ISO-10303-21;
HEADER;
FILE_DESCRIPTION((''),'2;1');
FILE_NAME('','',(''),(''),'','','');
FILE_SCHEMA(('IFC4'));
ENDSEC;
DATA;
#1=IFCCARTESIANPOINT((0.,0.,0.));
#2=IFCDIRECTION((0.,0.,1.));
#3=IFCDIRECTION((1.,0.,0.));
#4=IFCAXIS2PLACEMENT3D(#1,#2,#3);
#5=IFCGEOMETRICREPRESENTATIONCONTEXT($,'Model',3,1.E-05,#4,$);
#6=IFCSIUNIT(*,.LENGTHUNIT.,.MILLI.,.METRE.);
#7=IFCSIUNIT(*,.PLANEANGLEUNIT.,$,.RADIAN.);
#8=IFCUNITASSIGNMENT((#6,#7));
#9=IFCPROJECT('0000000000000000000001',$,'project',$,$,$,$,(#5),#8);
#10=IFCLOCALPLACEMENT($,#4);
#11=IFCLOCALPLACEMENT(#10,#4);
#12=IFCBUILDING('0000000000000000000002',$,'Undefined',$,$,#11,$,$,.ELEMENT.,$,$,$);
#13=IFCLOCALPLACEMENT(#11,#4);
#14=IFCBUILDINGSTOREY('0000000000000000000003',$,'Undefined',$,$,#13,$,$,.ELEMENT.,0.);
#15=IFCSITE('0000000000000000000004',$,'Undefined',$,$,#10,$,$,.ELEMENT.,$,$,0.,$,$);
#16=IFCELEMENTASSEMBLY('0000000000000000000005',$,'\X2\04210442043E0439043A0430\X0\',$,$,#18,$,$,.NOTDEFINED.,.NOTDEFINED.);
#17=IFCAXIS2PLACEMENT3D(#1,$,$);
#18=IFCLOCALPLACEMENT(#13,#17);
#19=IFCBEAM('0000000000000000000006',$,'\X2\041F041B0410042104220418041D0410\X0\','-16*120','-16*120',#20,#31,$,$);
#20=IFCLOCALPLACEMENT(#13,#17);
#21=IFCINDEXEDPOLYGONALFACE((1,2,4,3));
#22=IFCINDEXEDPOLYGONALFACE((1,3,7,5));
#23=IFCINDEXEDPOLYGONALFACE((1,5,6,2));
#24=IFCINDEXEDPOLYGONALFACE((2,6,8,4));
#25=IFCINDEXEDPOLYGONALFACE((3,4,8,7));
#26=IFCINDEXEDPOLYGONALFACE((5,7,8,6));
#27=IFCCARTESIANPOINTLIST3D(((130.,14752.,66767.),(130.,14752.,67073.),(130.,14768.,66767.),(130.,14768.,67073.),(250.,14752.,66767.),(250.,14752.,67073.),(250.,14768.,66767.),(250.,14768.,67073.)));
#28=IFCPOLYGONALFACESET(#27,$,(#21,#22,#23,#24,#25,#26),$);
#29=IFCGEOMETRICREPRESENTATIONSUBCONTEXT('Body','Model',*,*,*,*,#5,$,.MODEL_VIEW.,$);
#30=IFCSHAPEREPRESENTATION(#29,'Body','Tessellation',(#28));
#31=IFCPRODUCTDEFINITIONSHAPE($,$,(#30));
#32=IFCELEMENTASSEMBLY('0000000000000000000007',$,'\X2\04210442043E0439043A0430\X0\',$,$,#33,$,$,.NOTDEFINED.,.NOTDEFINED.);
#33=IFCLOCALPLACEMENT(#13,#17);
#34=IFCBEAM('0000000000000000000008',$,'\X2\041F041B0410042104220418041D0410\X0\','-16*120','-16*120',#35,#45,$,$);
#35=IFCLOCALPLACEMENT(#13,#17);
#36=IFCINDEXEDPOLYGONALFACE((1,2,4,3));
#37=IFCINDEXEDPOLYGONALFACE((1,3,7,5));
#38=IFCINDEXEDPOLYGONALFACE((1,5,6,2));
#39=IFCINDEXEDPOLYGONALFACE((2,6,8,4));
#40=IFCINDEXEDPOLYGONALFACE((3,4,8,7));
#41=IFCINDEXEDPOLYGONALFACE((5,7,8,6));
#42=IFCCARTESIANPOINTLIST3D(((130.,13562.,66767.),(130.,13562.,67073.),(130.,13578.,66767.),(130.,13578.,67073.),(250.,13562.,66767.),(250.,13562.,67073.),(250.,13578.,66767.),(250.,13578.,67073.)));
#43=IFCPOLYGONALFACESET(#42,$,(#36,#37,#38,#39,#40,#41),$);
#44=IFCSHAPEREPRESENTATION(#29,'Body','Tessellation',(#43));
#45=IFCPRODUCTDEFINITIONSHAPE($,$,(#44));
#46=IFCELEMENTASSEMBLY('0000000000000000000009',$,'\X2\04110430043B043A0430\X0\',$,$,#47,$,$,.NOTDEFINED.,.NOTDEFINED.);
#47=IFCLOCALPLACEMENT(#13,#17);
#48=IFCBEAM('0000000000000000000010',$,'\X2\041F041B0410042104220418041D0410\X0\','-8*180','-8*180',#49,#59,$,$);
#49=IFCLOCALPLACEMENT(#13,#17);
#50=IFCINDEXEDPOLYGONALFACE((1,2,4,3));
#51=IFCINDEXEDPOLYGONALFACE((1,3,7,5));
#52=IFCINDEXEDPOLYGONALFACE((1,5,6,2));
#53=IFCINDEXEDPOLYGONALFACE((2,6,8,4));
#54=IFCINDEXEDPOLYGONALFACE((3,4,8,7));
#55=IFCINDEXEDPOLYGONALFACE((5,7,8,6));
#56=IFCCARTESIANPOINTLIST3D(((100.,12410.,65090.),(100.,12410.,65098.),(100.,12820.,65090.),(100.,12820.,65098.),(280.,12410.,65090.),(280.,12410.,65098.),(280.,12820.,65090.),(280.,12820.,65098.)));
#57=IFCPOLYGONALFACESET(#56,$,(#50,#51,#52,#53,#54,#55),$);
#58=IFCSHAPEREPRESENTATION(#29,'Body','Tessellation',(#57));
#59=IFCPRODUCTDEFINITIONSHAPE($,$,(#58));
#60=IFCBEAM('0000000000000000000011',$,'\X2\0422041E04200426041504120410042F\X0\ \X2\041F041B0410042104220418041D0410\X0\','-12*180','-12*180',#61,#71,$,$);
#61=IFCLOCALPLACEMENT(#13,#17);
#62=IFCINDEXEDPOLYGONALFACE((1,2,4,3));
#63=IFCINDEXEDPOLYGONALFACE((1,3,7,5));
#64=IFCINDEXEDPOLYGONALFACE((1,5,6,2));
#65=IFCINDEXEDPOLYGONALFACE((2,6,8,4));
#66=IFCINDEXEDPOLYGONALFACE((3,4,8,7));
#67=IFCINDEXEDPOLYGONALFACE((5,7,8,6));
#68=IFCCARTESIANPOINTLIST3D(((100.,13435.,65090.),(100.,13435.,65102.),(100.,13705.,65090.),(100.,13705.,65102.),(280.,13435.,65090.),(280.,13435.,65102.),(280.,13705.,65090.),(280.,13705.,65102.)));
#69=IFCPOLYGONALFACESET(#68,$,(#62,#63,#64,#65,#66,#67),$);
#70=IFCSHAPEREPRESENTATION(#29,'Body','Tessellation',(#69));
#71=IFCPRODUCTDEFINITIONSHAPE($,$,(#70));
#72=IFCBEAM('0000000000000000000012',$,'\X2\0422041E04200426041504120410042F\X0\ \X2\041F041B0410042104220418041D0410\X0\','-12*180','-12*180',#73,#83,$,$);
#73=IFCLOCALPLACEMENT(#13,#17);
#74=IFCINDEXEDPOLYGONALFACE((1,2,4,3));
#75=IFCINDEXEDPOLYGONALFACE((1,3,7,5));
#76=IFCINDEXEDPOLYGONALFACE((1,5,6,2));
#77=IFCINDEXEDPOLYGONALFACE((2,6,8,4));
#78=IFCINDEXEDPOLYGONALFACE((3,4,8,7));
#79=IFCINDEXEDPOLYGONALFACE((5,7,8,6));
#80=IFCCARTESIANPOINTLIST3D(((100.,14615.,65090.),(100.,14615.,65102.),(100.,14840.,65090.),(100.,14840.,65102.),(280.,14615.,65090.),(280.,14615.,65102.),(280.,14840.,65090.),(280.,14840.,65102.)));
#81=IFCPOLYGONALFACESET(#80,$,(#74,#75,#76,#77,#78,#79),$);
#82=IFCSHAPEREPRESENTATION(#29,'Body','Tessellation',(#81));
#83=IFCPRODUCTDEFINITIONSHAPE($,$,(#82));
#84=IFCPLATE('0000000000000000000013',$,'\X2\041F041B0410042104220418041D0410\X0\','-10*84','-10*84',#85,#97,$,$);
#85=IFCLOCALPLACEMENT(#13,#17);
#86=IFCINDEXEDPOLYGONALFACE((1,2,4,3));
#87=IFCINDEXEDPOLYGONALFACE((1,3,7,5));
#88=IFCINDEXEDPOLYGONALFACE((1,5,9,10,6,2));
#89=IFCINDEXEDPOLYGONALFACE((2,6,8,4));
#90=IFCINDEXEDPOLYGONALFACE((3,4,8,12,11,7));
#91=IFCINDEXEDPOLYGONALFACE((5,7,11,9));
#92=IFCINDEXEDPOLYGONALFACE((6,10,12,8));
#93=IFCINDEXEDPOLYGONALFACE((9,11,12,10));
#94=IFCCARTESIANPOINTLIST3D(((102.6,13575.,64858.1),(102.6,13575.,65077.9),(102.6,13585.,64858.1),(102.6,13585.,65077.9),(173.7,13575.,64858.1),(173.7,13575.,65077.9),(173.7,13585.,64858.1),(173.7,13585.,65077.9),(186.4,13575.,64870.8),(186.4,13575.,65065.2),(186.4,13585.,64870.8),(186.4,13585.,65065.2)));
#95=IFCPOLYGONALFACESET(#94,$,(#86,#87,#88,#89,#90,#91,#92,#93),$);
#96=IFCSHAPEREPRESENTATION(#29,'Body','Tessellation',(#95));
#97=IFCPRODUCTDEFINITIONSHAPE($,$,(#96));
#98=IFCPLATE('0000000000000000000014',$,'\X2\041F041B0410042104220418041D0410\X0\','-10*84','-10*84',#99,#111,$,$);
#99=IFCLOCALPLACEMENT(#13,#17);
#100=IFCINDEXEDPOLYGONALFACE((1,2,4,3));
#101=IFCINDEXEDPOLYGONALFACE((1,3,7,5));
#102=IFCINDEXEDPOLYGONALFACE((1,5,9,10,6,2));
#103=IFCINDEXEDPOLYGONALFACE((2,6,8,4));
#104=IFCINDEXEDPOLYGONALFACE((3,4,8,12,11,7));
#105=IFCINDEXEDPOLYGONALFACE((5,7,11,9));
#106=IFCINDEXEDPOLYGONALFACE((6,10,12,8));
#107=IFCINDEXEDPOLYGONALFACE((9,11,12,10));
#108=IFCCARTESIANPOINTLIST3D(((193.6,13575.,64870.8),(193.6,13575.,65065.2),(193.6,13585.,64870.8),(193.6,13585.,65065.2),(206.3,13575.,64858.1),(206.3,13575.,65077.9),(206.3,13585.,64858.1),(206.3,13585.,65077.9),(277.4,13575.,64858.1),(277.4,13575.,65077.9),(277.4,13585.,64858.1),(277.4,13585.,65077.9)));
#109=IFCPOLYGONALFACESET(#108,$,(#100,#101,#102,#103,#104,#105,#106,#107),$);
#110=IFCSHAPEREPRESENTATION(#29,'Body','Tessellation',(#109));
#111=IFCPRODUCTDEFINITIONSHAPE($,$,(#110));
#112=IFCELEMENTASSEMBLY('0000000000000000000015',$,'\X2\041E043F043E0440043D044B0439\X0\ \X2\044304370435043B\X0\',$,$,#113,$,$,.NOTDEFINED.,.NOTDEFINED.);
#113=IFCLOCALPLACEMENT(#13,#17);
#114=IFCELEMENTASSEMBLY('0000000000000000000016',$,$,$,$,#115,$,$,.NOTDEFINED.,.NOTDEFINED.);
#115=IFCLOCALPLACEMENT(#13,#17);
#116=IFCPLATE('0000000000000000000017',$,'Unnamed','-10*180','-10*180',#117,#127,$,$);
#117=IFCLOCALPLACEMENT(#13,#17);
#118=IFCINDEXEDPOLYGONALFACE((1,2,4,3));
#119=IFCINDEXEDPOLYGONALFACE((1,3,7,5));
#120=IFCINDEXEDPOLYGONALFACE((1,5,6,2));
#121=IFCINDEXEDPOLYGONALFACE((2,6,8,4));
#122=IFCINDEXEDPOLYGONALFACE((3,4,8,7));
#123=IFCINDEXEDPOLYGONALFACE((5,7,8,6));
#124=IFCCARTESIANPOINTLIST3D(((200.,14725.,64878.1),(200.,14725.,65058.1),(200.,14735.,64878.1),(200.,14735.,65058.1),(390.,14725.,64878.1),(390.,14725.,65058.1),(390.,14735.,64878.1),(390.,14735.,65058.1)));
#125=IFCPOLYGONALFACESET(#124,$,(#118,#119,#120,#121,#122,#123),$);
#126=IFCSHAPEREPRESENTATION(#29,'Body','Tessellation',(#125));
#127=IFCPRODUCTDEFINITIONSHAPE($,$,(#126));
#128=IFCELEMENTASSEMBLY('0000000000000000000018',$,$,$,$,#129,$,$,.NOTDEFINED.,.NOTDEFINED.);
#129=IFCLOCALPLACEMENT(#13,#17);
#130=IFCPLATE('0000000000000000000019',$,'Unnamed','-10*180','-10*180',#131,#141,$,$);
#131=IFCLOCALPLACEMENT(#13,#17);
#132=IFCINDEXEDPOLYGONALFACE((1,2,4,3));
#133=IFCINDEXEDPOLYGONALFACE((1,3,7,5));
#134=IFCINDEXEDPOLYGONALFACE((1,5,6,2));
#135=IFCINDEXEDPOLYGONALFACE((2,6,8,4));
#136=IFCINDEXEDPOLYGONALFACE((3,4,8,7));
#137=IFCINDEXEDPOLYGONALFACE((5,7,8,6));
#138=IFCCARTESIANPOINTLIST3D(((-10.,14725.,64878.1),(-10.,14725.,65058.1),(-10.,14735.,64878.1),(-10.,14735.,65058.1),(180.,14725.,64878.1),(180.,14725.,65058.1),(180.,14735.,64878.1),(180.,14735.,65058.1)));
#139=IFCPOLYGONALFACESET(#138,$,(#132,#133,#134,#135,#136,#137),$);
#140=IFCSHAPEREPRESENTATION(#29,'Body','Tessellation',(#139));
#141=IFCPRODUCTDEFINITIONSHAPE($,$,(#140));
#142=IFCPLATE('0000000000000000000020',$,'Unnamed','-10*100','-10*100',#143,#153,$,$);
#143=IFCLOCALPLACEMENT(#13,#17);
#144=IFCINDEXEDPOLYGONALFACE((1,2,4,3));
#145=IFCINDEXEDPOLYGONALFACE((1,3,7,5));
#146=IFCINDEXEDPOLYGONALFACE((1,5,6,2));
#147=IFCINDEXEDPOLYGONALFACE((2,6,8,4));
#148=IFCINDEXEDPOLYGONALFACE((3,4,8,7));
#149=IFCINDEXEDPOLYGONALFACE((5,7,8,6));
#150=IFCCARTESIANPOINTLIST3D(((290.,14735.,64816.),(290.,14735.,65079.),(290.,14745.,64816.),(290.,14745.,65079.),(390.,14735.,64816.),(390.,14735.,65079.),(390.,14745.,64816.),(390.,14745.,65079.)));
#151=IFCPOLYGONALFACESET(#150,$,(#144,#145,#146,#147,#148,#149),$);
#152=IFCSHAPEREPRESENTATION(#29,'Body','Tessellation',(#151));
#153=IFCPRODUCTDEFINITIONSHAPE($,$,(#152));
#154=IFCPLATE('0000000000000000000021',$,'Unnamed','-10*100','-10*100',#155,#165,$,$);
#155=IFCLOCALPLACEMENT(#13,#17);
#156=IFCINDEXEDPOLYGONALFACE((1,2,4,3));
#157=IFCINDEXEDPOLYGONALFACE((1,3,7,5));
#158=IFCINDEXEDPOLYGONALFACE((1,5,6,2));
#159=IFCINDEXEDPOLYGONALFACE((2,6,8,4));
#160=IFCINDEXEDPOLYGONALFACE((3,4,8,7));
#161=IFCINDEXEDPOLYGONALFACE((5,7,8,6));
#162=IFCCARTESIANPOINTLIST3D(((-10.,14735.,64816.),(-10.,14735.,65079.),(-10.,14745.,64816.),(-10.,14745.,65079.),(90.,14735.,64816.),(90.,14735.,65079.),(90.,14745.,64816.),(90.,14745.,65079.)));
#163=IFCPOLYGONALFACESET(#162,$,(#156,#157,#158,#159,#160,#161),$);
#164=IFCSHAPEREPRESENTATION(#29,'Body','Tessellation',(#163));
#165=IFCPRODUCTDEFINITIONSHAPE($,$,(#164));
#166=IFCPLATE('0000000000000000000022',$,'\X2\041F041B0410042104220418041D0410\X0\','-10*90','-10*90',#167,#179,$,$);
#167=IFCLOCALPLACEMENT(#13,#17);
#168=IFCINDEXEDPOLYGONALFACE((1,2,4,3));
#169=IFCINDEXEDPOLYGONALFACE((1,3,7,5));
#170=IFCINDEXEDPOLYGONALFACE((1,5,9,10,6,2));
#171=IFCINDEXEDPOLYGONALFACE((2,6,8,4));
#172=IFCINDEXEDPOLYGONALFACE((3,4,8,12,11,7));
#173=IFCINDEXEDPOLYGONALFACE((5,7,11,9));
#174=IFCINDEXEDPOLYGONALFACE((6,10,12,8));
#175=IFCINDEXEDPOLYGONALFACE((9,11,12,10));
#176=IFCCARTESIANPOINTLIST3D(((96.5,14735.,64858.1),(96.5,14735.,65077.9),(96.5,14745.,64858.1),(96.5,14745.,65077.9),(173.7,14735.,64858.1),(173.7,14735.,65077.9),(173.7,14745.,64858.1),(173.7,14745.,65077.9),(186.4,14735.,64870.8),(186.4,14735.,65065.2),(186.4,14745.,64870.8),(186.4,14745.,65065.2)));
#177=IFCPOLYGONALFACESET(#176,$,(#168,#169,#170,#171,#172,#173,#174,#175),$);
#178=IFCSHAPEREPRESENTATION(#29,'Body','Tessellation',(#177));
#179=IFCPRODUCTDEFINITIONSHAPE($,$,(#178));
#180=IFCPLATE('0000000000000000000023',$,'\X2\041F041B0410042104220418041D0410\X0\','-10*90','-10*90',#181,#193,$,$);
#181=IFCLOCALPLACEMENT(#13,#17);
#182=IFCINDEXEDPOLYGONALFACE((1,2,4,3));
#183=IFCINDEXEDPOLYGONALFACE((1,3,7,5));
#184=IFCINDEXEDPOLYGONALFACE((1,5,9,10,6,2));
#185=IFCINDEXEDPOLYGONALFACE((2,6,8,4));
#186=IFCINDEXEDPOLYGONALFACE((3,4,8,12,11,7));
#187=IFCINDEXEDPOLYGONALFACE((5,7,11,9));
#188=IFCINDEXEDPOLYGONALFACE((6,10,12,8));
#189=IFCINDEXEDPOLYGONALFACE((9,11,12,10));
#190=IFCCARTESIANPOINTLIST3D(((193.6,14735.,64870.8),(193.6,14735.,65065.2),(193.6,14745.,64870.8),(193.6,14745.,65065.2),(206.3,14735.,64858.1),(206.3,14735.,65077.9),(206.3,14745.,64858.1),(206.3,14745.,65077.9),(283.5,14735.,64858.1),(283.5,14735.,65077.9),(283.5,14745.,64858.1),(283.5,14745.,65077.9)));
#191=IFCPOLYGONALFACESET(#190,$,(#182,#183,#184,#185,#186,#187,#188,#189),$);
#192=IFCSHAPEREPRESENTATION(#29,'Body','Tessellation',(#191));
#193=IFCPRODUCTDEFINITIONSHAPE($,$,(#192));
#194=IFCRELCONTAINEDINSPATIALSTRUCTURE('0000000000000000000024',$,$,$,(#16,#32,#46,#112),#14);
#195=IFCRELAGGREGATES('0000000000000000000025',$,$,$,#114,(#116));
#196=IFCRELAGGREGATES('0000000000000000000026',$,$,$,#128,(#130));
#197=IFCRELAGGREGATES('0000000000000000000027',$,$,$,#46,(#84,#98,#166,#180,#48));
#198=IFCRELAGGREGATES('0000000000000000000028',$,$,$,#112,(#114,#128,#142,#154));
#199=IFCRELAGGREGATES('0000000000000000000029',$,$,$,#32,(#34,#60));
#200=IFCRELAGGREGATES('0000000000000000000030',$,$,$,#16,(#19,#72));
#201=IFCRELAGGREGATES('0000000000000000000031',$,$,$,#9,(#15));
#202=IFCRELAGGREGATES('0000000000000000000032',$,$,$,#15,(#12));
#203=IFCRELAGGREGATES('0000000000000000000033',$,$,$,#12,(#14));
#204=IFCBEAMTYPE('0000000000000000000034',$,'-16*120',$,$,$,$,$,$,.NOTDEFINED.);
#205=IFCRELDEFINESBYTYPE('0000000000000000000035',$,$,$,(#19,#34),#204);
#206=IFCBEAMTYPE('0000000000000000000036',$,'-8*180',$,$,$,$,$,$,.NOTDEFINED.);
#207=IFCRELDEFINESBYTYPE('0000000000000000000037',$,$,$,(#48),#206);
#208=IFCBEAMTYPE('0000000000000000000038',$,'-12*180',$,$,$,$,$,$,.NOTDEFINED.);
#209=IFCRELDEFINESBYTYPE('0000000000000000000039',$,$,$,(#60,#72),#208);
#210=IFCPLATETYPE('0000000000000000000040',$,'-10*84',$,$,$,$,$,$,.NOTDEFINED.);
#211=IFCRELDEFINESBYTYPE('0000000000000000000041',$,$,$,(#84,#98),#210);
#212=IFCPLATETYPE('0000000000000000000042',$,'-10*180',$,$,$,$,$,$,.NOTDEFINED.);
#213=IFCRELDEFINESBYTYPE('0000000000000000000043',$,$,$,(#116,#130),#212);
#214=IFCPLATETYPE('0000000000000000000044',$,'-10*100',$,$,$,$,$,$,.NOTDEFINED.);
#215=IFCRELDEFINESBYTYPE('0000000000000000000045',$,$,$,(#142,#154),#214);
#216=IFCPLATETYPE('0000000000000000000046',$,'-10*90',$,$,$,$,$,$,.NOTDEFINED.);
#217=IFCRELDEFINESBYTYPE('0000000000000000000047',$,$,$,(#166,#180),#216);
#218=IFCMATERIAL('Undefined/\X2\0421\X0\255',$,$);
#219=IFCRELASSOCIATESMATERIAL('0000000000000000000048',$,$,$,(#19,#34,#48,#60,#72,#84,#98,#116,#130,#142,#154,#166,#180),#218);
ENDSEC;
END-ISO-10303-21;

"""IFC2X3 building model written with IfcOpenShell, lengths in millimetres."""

from ifc_helpers import new_model, si_unit, frame, origin_with_axes, origin_2d_with_axis, place, context, subcontext, project, spatial, polyline, rectangle, outline, extrude, material, type_object, element, aggregate, save


model = new_model("IFC2X3")

# Units and contexts
model_context = context("Model", 3, precision=1e-05, world=origin_with_axes())
body_context = subcontext(model_context, "Body", "Model", "MODEL_VIEW")
ifc_project = project(units=[si_unit("LENGTHUNIT", "METRE", prefix="MILLI"), si_unit("PLANEANGLEUNIT", "RADIAN")], contexts=[model_context])

# Site, building, storey
site_placement = place(None, origin_with_axes())
site = spatial("IfcSite", under=ifc_project, at=site_placement, Name="Undefined", CompositionType="ELEMENT", RefElevation=0.0)
building_placement = place(site_placement, origin_with_axes())
building = spatial("IfcBuilding", under=site, at=building_placement, Name="Undefined", CompositionType="ELEMENT")
storey_placement = place(building_placement, origin_with_axes())
storey = spatial("IfcBuildingStorey", under=building, at=storey_placement, Name="Undefined", CompositionType="ELEMENT", Elevation=0.0)

# Element assemblies, beams
assembly_1_placement = place(storey_placement, origin_with_axes())
assembly_1 = element("IfcElementAssembly", 1, at=assembly_1_placement, inside=storey, Name="Стойка", AssemblyPlace="NOTDEFINED", PredefinedType="NOTDEFINED")
ifc_material_1 = material(Name="Undefined/С255")
beam_type_1 = type_object("IfcBeamType", Name="-16*120", PredefinedType="NOTDEFINED")
beam_1_placement = place(assembly_1_placement, frame((190.0, 14760.0, 66767.0), z_axis=(1.0, 0.0, 0.0), x_axis=(0.0, 0.0, 1.0)))
beam_1 = element("IfcBeam", 2, at=beam_1_placement, type_object=beam_type_1, material=ifc_material_1, Name="ПЛАСТИНА", Description="-16*120", ObjectType="-16*120", context=body_context, shape_type="SweptSolid", body=[
    extrude(rectangle(XDim=16.0, YDim=120.0, at=origin_2d_with_axis()), frame((306.0, 0.0, 0.0), z_axis=(-1.0, 0.0, 0.0), x_axis=(0.0, -1.0, 0.0)), (0.0, 0.0, 1.0), 306.0),
])
assembly_2_placement = place(storey_placement, origin_with_axes())
assembly_2 = element("IfcElementAssembly", 3, at=assembly_2_placement, inside=storey, Name="Стойка", AssemblyPlace="NOTDEFINED", PredefinedType="NOTDEFINED")
beam_2_placement = place(assembly_2_placement, frame((190.0, 13570.0, 66767.0), z_axis=(1.0, 0.0, 0.0), x_axis=(0.0, 0.0, 1.0)))
beam_2 = element("IfcBeam", 4, at=beam_2_placement, type_object=beam_type_1, material=ifc_material_1, Name="ПЛАСТИНА", Description="-16*120", ObjectType="-16*120", context=body_context, shape_type="SweptSolid", body=[
    extrude(rectangle(XDim=16.0, YDim=120.0, at=origin_2d_with_axis()), frame((306.0, 0.0, 0.0), z_axis=(-1.0, 0.0, 0.0), x_axis=(0.0, -1.0, 0.0)), (0.0, 0.0, 1.0), 306.0),
])
assembly_3_placement = place(storey_placement, origin_with_axes())
assembly_3 = element("IfcElementAssembly", 5, at=assembly_3_placement, inside=storey, Name="Балка", AssemblyPlace="NOTDEFINED", PredefinedType="NOTDEFINED")
beam_type_2 = type_object("IfcBeamType", Name="-8*180", PredefinedType="NOTDEFINED")
beam_3_placement = place(assembly_3_placement, frame((190.0, 12820.0, 65094.0), z_axis=(-1.0, 0.0, 0.0), x_axis=(0.0, -1.0, 0.0)))
beam_3 = element("IfcBeam", 6, at=beam_3_placement, type_object=beam_type_2, material=ifc_material_1, Name="ПЛАСТИНА", Description="-8*180", ObjectType="-8*180", context=body_context, shape_type="SweptSolid", body=[
    extrude(rectangle(XDim=8.0, YDim=180.0, at=origin_2d_with_axis()), frame((410.0, 0.0, 0.0), z_axis=(-1.0, 0.0, 0.0), x_axis=(0.0, -1.0, 0.0)), (0.0, 0.0, 1.0), 410.0),
])

# Beams
beam_type_3 = type_object("IfcBeamType", Name="-12*180", PredefinedType="NOTDEFINED")
beam_4_placement = place(assembly_2_placement, frame((190.0, 13705.0, 65096.0), z_axis=(1.0, 0.0, 0.0), x_axis=(0.0, -1.0, 0.0)))
beam_4 = element("IfcBeam", 7, at=beam_4_placement, type_object=beam_type_3, material=ifc_material_1, Name="ТОРЦЕВАЯ ПЛАСТИНА", Description="-12*180", ObjectType="-12*180", context=body_context, shape_type="SweptSolid", body=[
    extrude(rectangle(XDim=12.0, YDim=180.0, at=origin_2d_with_axis()), frame((270.0, 0.0, 0.0), z_axis=(-1.0, 0.0, 0.0), x_axis=(0.0, -1.0, 0.0)), (0.0, 0.0, 1.0), 270.0),
])
beam_5_placement = place(assembly_1_placement, frame((190.0, 14615.0, 65096.0), z_axis=(-1.0, 0.0, 0.0), x_axis=(0.0, 1.0, 0.0)))
beam_5 = element("IfcBeam", 8, at=beam_5_placement, type_object=beam_type_3, material=ifc_material_1, Name="ТОРЦЕВАЯ ПЛАСТИНА", Description="-12*180", ObjectType="-12*180", context=body_context, shape_type="SweptSolid", body=[
    extrude(rectangle(XDim=12.0, YDim=180.0, at=origin_2d_with_axis()), frame((225.0, 0.0, 0.0), z_axis=(-1.0, 0.0, 0.0), x_axis=(0.0, -1.0, 0.0)), (0.0, 0.0, 1.0), 225.0),
])

# Plates
plate_type_1 = type_object("IfcPlateType", Name="-10*84", PredefinedType="NOTDEFINED")
plate_1_placement = place(assembly_3_placement, frame((186.4, 13580.0, 65077.9), z_axis=(0.0, -1.0, 0.0), x_axis=(-1.0, 0.0, 0.0)))
plate_1 = element("IfcPlate", 9, at=plate_1_placement, type_object=plate_type_1, material=ifc_material_1, Name="ПЛАСТИНА", Description="-10*84", ObjectType="-10*84", context=body_context, shape_type="SweptSolid", body=[
    extrude(outline(polyline([(0.0, 12.7), (12.7, 0.0), (83.8, 0.0), (83.8, 219.8), (12.7, 219.8), (0.0, 207.1), (0.0, 12.7)])), frame((0.0, 0.0, -5.0), z_axis=(0.0, 0.0, 1.0), x_axis=(1.0, 0.0, 0.0)), (0.0, 0.0, 1.0), 10.0),
])
plate_2_placement = place(assembly_3_placement, frame((277.4, 13580.0, 65077.9), z_axis=(0.0, -1.0, 0.0), x_axis=(-1.0, 0.0, 0.0)))
plate_2 = element("IfcPlate", 10, at=plate_2_placement, type_object=plate_type_1, material=ifc_material_1, Name="ПЛАСТИНА", Description="-10*84", ObjectType="-10*84", context=body_context, shape_type="SweptSolid", body=[
    extrude(outline(polyline([(0.0, 0.0), (71.1, 0.0), (83.8, 12.7), (83.8, 207.1), (71.1, 219.8), (0.0, 219.8), (0.0, 0.0)])), frame((0.0, 0.0, -5.0), z_axis=(0.0, 0.0, 1.0), x_axis=(1.0, 0.0, 0.0)), (0.0, 0.0, 1.0), 10.0),
])

# Element assemblies, plates
assembly_4_placement = place(storey_placement, origin_with_axes())
assembly_4 = element("IfcElementAssembly", 11, at=assembly_4_placement, inside=storey, Name="Опорный узел", AssemblyPlace="NOTDEFINED", PredefinedType="NOTDEFINED")
assembly_5_placement = place(assembly_4_placement, origin_with_axes())
assembly_5 = element("IfcElementAssembly", 12, at=assembly_5_placement, AssemblyPlace="NOTDEFINED", PredefinedType="NOTDEFINED")
plate_type_2 = type_object("IfcPlateType", Name="-10*180", PredefinedType="NOTDEFINED")
plate_3_placement = place(assembly_5_placement, frame((390.0, 14730.0, 65058.1), z_axis=(0.0, -1.0, 0.0), x_axis=(-1.0, 0.0, 0.0)))
plate_3 = element("IfcPlate", 13, at=plate_3_placement, type_object=plate_type_2, material=ifc_material_1, Name="Unnamed", Description="-10*180", ObjectType="-10*180", context=body_context, shape_type="SweptSolid", body=[
    extrude(outline(polyline([(0.0, 0.0), (190.0, 0.0), (190.0, 180.0), (0.0, 180.0), (0.0, 0.0)])), frame((0.0, 0.0, -5.0), z_axis=(0.0, 0.0, 1.0), x_axis=(1.0, 0.0, 0.0)), (0.0, 0.0, 1.0), 10.0),
])
aggregate(assembly_5, [plate_3])
assembly_6_placement = place(assembly_4_placement, origin_with_axes())
assembly_6 = element("IfcElementAssembly", 14, at=assembly_6_placement, AssemblyPlace="NOTDEFINED", PredefinedType="NOTDEFINED")
plate_4_placement = place(assembly_6_placement, frame((180.0, 14730.0, 65058.1), z_axis=(0.0, -1.0, 0.0), x_axis=(-1.0, 0.0, 0.0)))
plate_4 = element("IfcPlate", 15, at=plate_4_placement, type_object=plate_type_2, material=ifc_material_1, Name="Unnamed", Description="-10*180", ObjectType="-10*180", context=body_context, shape_type="SweptSolid", body=[
    extrude(outline(polyline([(0.0, 0.0), (190.0, 0.0), (190.0, 180.0), (0.0, 180.0), (0.0, 0.0)])), frame((0.0, 0.0, -5.0), z_axis=(0.0, 0.0, 1.0), x_axis=(1.0, 0.0, 0.0)), (0.0, 0.0, 1.0), 10.0),
])
aggregate(assembly_6, [plate_4])
plate_type_3 = type_object("IfcPlateType", Name="-10*100", PredefinedType="NOTDEFINED")
plate_5_placement = place(assembly_4_placement, frame((290.0, 14740.0, 64816.0), z_axis=(0.0, 1.0, 0.0), x_axis=(0.0, 0.0, 1.0)))
plate_5 = element("IfcPlate", 16, at=plate_5_placement, type_object=plate_type_3, material=ifc_material_1, Name="Unnamed", Description="-10*100", ObjectType="-10*100", context=body_context, shape_type="SweptSolid", body=[
    extrude(outline(polyline([(0.0, 0.0), (263.0, 0.0), (263.0, 100.0), (0.0, 100.0), (0.0, 0.0)])), frame((0.0, 0.0, -5.0), z_axis=(0.0, 0.0, 1.0), x_axis=(1.0, 0.0, 0.0)), (0.0, 0.0, 1.0), 10.0),
])
plate_6_placement = place(assembly_4_placement, frame((-10.0, 14740.0, 64816.0), z_axis=(0.0, 1.0, 0.0), x_axis=(0.0, 0.0, 1.0)))
plate_6 = element("IfcPlate", 17, at=plate_6_placement, type_object=plate_type_3, material=ifc_material_1, Name="Unnamed", Description="-10*100", ObjectType="-10*100", context=body_context, shape_type="SweptSolid", body=[
    extrude(outline(polyline([(0.0, 0.0), (263.0, 0.0), (263.0, 100.0), (0.0, 100.0), (0.0, 0.0)])), frame((0.0, 0.0, -5.0), z_axis=(0.0, 0.0, 1.0), x_axis=(1.0, 0.0, 0.0)), (0.0, 0.0, 1.0), 10.0),
])

# Plates
plate_type_4 = type_object("IfcPlateType", Name="-10*90", PredefinedType="NOTDEFINED")
plate_7_placement = place(assembly_3_placement, frame((186.4, 14740.0, 65077.9), z_axis=(0.0, -1.0, 0.0), x_axis=(-1.0, 0.0, 0.0)))
plate_7 = element("IfcPlate", 18, at=plate_7_placement, type_object=plate_type_4, material=ifc_material_1, Name="ПЛАСТИНА", Description="-10*90", ObjectType="-10*90", context=body_context, shape_type="SweptSolid", body=[
    extrude(outline(polyline([(0.0, 12.7), (12.7, 0.0), (89.9, 0.0), (89.9, 219.8), (12.7, 219.8), (0.0, 207.1), (0.0, 12.7)])), frame((0.0, 0.0, -5.0), z_axis=(0.0, 0.0, 1.0), x_axis=(1.0, 0.0, 0.0)), (0.0, 0.0, 1.0), 10.0),
])
plate_8_placement = place(assembly_3_placement, frame((283.5, 14740.0, 65077.9), z_axis=(0.0, -1.0, 0.0), x_axis=(-1.0, 0.0, 0.0)))
plate_8 = element("IfcPlate", 19, at=plate_8_placement, type_object=plate_type_4, material=ifc_material_1, Name="ПЛАСТИНА", Description="-10*90", ObjectType="-10*90", context=body_context, shape_type="SweptSolid", body=[
    extrude(outline(polyline([(0.0, 0.0), (77.2, 0.0), (89.9, 12.7), (89.9, 207.1), (77.2, 219.8), (0.0, 219.8), (0.0, 0.0)])), frame((0.0, 0.0, -5.0), z_axis=(0.0, 0.0, 1.0), x_axis=(1.0, 0.0, 0.0)), (0.0, 0.0, 1.0), 10.0),
])

aggregate(assembly_3, [plate_1, plate_2, plate_7, plate_8, beam_3])
aggregate(assembly_4, [assembly_5, assembly_6, plate_5, plate_6])

aggregate(assembly_2, [beam_2, beam_4])
aggregate(assembly_1, [beam_1, beam_5])

save(model, "model.ifc")
